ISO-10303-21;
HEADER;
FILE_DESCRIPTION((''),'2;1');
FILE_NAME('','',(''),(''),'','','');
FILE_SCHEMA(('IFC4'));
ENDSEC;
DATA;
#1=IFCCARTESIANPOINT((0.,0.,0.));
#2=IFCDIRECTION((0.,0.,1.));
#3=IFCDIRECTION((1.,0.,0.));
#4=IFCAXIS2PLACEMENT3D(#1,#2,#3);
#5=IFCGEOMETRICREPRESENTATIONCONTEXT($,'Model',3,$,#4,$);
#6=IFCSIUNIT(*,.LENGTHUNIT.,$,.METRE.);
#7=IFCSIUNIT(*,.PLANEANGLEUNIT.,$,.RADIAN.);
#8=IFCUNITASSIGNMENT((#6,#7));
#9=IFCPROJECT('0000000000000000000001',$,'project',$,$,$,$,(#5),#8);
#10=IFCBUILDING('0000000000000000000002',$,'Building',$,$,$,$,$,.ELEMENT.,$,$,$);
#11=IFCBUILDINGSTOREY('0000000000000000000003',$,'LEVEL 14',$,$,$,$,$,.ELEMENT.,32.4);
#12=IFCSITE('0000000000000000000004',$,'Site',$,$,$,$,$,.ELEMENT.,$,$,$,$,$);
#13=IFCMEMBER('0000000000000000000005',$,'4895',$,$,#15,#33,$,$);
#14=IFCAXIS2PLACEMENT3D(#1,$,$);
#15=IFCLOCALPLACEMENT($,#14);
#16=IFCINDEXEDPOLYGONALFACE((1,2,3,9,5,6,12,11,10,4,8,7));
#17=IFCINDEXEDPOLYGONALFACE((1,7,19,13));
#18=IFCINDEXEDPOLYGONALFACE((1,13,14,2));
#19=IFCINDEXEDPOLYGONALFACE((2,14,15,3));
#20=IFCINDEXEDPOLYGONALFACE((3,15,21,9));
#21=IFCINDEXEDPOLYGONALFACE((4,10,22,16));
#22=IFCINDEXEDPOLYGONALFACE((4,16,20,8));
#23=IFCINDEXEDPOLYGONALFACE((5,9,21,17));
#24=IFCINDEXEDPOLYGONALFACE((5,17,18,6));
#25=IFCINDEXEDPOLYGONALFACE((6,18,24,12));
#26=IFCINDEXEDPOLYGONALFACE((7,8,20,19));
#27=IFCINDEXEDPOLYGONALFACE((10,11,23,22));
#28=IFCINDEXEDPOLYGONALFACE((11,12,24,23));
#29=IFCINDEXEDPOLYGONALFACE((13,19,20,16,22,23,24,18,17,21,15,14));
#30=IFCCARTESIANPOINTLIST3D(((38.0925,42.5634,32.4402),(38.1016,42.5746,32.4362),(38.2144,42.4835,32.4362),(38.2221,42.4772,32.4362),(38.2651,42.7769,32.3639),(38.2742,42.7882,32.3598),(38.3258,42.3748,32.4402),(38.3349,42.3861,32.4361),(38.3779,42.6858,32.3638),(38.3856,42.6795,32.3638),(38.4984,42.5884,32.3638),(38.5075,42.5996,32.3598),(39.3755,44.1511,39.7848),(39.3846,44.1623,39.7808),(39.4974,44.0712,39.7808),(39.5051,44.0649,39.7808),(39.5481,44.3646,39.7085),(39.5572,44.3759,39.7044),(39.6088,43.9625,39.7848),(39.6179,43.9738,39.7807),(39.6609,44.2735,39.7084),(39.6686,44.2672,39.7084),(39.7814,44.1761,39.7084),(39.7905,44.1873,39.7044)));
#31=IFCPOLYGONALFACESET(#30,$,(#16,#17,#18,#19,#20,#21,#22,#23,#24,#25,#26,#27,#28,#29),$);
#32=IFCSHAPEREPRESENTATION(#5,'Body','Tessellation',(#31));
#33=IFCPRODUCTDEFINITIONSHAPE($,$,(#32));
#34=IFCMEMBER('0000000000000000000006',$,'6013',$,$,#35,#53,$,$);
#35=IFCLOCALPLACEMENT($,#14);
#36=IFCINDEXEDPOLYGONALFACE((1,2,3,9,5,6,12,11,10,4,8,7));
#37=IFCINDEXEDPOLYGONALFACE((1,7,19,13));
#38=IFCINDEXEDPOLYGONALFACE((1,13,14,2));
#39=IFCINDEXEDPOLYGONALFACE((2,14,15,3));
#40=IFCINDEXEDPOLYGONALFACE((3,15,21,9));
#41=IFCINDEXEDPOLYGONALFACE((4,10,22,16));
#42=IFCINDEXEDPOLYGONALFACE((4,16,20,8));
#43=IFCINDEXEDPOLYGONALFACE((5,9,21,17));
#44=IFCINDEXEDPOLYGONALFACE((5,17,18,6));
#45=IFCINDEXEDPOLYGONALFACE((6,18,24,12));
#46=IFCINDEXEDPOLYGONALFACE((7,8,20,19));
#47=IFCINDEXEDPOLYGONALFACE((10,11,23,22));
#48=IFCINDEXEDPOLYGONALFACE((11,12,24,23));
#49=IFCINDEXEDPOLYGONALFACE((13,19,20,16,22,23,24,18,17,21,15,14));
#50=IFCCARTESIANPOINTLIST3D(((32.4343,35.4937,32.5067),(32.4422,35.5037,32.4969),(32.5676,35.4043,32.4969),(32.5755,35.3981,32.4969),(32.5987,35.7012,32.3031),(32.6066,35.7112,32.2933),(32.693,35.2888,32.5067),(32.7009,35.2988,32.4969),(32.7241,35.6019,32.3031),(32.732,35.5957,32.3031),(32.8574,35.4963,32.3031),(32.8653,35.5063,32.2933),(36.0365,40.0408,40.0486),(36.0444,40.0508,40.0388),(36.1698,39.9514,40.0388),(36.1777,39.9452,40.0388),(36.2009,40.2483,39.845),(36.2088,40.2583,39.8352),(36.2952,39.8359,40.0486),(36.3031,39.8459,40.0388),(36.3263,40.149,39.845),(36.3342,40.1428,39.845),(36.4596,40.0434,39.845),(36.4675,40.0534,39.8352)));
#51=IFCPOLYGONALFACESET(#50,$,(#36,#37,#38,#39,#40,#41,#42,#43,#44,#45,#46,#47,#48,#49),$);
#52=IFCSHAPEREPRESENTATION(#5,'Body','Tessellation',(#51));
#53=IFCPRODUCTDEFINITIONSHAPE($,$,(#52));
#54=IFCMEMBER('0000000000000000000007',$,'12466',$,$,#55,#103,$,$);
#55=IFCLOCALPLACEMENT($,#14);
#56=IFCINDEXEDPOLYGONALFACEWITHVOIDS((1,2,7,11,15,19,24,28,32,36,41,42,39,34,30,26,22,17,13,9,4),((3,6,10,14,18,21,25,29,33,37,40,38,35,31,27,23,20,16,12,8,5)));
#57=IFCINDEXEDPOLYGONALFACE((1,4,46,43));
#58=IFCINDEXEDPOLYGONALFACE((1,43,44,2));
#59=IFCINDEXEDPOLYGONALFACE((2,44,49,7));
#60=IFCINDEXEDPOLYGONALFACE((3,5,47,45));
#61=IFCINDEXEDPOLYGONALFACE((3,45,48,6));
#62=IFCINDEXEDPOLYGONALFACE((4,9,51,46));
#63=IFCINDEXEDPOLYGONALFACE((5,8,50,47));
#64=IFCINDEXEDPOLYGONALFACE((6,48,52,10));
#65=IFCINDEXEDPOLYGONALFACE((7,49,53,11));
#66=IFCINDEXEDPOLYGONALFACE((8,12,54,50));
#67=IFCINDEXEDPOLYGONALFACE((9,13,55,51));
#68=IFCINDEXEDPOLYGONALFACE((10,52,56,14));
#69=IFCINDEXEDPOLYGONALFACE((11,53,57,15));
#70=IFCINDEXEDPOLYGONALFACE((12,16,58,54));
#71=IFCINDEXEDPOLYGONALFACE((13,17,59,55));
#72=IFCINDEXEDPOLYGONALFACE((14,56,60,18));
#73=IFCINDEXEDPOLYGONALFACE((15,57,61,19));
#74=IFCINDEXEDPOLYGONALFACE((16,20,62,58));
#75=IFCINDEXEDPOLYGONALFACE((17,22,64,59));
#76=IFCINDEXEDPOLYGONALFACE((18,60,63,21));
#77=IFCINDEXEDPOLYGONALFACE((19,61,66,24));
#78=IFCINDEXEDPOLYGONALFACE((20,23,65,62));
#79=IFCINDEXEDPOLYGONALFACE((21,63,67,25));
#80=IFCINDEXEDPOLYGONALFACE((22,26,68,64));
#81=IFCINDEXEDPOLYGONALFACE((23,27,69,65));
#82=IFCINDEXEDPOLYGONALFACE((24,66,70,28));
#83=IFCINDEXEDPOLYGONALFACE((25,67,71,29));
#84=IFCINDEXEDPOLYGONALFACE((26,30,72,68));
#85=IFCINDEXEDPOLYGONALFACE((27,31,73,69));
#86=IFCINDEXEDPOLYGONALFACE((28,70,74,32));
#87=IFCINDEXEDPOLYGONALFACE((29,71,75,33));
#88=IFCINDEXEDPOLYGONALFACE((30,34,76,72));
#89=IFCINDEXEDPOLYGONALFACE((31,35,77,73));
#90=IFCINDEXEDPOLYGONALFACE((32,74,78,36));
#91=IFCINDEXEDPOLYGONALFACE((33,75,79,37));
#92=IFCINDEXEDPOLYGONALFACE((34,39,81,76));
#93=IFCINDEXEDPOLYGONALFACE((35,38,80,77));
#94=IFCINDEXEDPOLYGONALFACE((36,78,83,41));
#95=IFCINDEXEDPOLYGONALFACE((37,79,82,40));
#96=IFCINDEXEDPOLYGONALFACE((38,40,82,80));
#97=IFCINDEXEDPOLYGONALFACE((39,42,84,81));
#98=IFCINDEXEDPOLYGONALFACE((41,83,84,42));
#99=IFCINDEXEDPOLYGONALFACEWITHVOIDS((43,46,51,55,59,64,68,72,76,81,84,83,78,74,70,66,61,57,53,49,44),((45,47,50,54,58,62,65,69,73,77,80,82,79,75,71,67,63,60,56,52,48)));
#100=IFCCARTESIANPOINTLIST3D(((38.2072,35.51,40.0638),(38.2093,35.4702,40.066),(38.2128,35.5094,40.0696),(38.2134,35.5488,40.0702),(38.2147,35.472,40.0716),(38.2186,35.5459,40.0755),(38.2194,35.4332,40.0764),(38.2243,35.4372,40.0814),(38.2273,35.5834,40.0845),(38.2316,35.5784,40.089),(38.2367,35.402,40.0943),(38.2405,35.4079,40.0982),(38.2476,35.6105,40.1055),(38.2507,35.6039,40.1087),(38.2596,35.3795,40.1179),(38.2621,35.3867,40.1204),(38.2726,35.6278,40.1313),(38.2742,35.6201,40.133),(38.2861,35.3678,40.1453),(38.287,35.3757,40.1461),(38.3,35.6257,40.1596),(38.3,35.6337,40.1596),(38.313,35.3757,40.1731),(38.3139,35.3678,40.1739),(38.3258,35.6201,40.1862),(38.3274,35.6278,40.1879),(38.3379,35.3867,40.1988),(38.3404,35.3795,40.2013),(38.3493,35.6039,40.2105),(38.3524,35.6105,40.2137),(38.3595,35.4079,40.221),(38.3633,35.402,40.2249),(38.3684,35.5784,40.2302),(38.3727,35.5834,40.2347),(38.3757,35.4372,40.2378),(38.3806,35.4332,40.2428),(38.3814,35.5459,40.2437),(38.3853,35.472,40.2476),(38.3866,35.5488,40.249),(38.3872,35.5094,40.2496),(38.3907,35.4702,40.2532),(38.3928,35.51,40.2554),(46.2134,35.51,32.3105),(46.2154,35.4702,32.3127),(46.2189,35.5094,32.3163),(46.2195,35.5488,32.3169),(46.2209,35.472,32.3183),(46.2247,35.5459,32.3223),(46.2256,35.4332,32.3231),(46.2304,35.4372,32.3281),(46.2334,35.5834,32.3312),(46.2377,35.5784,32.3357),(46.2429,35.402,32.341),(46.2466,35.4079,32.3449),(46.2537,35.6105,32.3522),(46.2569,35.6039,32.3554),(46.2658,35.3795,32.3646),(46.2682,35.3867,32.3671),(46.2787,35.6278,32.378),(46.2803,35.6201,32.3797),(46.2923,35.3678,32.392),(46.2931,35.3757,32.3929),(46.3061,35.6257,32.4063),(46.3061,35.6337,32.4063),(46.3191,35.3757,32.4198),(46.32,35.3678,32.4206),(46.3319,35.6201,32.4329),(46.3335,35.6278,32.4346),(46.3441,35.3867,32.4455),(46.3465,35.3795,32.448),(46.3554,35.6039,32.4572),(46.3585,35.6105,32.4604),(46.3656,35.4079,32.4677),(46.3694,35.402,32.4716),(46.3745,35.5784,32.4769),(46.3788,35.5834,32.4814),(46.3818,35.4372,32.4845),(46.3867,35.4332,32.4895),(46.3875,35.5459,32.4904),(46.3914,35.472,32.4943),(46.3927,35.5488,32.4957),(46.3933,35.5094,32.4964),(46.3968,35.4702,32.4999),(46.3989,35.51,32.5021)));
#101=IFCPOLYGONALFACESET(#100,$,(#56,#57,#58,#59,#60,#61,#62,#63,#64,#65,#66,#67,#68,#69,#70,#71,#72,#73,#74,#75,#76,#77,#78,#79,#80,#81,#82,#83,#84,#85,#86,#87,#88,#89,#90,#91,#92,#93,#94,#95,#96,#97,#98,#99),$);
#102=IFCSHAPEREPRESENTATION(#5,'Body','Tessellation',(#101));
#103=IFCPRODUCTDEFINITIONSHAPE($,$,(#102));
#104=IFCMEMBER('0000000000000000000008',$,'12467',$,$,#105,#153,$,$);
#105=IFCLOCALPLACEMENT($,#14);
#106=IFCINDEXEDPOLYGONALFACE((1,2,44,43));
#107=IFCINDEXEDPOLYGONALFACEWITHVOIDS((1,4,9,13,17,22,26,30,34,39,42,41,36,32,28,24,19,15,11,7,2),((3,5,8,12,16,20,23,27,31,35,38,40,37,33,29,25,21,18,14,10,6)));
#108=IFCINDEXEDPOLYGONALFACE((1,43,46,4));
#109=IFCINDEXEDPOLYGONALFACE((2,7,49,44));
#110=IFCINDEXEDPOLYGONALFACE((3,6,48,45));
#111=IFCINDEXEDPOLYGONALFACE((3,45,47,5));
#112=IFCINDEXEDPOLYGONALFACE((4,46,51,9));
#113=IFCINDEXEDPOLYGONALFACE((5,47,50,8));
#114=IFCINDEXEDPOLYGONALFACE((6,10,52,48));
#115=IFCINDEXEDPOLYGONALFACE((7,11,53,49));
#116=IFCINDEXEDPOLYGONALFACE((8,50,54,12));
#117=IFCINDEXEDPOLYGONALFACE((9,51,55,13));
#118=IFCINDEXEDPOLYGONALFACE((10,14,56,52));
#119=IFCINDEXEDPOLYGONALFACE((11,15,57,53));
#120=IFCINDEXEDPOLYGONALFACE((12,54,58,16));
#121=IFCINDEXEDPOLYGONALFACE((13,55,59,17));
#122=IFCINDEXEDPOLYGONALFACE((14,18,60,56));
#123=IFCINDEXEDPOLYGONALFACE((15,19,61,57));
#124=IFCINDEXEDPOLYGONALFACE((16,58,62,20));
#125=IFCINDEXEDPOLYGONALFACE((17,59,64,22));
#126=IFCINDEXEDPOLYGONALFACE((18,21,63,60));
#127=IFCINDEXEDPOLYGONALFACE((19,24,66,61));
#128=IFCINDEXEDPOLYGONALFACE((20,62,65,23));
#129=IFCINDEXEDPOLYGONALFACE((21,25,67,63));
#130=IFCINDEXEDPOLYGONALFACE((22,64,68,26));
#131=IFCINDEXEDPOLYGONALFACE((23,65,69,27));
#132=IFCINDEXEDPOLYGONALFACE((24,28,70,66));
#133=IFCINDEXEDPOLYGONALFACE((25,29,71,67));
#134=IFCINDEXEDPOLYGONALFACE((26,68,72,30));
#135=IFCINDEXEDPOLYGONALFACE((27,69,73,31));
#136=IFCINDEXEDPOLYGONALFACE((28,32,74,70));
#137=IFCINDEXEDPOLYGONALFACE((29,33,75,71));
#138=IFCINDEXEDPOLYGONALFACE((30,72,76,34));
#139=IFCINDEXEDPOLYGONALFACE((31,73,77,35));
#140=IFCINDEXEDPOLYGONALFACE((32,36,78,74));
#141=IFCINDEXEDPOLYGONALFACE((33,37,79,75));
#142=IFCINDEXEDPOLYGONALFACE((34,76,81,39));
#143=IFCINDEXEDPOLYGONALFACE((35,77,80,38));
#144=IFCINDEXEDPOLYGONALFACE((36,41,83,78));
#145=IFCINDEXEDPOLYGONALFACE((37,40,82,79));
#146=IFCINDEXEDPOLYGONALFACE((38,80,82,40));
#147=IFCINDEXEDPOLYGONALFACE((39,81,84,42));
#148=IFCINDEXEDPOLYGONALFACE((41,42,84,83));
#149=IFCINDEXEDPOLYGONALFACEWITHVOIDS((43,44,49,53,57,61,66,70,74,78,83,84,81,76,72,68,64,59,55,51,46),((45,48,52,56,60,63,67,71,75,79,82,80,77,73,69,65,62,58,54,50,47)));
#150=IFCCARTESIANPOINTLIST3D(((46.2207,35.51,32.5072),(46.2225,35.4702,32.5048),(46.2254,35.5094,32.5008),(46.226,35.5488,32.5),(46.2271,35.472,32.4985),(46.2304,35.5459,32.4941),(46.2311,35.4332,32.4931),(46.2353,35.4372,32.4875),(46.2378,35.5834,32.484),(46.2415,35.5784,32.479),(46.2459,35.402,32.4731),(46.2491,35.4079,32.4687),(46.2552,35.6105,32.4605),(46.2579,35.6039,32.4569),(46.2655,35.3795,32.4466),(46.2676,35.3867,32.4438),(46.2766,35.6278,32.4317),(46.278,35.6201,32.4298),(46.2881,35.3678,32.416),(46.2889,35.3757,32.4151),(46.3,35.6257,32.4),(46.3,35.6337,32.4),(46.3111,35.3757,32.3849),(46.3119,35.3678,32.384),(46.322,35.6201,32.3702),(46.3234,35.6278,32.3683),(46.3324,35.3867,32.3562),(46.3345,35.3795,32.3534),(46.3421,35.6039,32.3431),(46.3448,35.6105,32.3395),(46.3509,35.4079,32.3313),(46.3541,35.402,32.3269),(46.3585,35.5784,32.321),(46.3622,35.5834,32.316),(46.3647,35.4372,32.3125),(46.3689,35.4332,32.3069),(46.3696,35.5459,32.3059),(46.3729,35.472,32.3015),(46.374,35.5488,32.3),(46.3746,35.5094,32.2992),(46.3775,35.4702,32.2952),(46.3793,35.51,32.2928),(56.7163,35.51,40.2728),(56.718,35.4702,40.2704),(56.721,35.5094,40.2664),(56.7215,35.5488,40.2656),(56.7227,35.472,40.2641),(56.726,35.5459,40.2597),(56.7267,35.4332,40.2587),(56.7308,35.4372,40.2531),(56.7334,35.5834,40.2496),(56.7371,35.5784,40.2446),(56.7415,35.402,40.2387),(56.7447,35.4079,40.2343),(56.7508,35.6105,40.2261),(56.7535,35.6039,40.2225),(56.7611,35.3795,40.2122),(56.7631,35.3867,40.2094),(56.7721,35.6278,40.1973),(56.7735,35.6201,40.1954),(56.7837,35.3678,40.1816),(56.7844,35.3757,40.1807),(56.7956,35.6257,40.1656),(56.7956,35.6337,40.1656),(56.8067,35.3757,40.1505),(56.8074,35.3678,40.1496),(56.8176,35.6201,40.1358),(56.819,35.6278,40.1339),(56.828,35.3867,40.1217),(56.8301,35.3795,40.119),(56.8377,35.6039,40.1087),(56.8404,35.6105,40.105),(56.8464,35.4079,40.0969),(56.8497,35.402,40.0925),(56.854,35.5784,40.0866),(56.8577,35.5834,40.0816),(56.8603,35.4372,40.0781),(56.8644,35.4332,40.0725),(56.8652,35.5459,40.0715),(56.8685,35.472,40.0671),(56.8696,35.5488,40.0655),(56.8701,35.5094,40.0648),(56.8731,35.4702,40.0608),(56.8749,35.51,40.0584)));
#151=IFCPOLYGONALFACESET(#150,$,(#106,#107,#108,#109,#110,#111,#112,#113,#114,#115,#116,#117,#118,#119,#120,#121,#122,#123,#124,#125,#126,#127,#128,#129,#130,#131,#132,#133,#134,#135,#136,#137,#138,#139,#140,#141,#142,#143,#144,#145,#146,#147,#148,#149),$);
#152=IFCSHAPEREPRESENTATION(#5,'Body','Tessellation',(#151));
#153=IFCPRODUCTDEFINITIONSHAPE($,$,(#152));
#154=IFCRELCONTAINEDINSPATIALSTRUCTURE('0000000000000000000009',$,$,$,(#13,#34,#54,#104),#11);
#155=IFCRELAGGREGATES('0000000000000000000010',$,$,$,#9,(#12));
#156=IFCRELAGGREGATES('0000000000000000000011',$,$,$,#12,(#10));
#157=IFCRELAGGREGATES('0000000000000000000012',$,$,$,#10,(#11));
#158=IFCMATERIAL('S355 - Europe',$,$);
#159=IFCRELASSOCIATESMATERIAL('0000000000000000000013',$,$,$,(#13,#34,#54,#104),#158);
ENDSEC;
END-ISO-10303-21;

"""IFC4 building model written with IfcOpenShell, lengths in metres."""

from ifc_helpers import new_model, si_unit, frame, origin_with_axes, origin_2d_with_axis, place, context, project, spatial, hollow_circle, i_section, extrude, material, material_profile, profile_set, profile_usage, element, save


model = new_model("IFC4")

# Units and contexts
model_context = context("Model", 3, world=origin_with_axes())
ifc_project = project(units=[si_unit("LENGTHUNIT", "METRE"), si_unit("PLANEANGLEUNIT", "RADIAN")], contexts=[model_context])

# Site, building, storey
site = spatial("IfcSite", under=ifc_project, Name="Site", CompositionType="ELEMENT")
building = spatial("IfcBuilding", under=site, Name="Building", CompositionType="ELEMENT")
storey = spatial("IfcBuildingStorey", under=building, Name="LEVEL 14", CompositionType="ELEMENT", Elevation=32.4)

# Shared definitions
ifc_material = material(Name="S355 - Europe")

# Members
ifc_material_profile_1 = material_profile(ifc_material, i_section(OverallWidth=0.3, OverallDepth=0.3, WebThickness=0.01, FlangeThickness=0.015, at=origin_2d_with_axis()))
ifc_profile_set_1 = profile_set([ifc_material_profile_1])
ifc_profile_usage_1 = profile_usage(ifc_profile_set_1, cardinal=10)
member_1_placement = place(None, frame((38.3, 42.5815, 32.4), z_axis=(0.168307, 0.208278, 0.96348), x_axis=(-0.777826, 0.62848, 0.0)))
element("IfcMember", 1, at=member_1_placement, inside=storey, material=ifc_profile_usage_1, Name="4895", context=model_context, shape_type="SweptSolid", body=[
    extrude(i_section(OverallWidth=0.3, OverallDepth=0.3, WebThickness=0.01, FlangeThickness=0.015, at=origin_2d_with_axis()), origin_with_axes(), (0.0, 0.0, 1.0), 7.623),
])
ifc_material_profile_2 = material_profile(ifc_material, i_section(OverallWidth=0.33, OverallDepth=0.35, WebThickness=0.01, FlangeThickness=0.016, at=origin_2d_with_axis()))
ifc_profile_set_2 = profile_set([ifc_material_profile_2])
ifc_profile_usage_2 = profile_usage(ifc_profile_set_2, cardinal=10)
member_2_placement = place(None, frame((36.252, 40.0471, 39.9419), z_axis=(-0.378587, -0.477895, -0.792646), x_axis=(0.783843, -0.620959, 0.0)))
element("IfcMember", 2, at=member_2_placement, inside=storey, material=ifc_profile_usage_2, Name="6013", context=model_context, shape_type="SweptSolid", body=[
    extrude(i_section(OverallWidth=0.33, OverallDepth=0.35, WebThickness=0.01, FlangeThickness=0.016, at=origin_2d_with_axis()), origin_with_axes(), (0.0, 0.0, 1.0), 9.5148),
])
ifc_material_profile_3 = material_profile(ifc_material, hollow_circle(Radius=0.1337, WallThickness=0.008, at=origin_2d_with_axis()))
ifc_profile_set_3 = profile_set([ifc_material_profile_3])
ifc_profile_usage_3 = profile_usage(ifc_profile_set_3, cardinal=10)
member_3_placement = place(None, frame((38.3, 35.5, 40.1596), z_axis=(0.718358, 0.0, -0.695673), x_axis=(0.0, 1.0, 0.0)))
element("IfcMember", 3, at=member_3_placement, inside=storey, material=ifc_profile_usage_3, Name="12466", context=model_context, shape_type="SweptSolid", body=[
    extrude(hollow_circle(Radius=0.1337, WallThickness=0.008, at=origin_2d_with_axis()), origin_with_axes(), (0.0, 0.0, 1.0), 11.145),
])
ifc_material_profile_4 = material_profile(ifc_material, hollow_circle(Radius=0.1337, WallThickness=0.008, at=origin_2d_with_axis()))
ifc_profile_set_4 = profile_set([ifc_material_profile_4])
ifc_profile_usage_4 = profile_usage(ifc_profile_set_4, cardinal=10)
member_4_placement = place(None, frame((46.3, 35.5, 32.4), z_axis=(0.803883, 0.0, 0.594787), x_axis=(0.0, 1.0, 0.0)))
element("IfcMember", 4, at=member_4_placement, inside=storey, material=ifc_profile_usage_4, Name="12467", context=model_context, shape_type="SweptSolid", body=[
    extrude(hollow_circle(Radius=0.1337, WallThickness=0.008, at=origin_2d_with_axis()), origin_with_axes(), (0.0, 0.0, 1.0), 13.0561),
])

save(model, "model.ifc")
